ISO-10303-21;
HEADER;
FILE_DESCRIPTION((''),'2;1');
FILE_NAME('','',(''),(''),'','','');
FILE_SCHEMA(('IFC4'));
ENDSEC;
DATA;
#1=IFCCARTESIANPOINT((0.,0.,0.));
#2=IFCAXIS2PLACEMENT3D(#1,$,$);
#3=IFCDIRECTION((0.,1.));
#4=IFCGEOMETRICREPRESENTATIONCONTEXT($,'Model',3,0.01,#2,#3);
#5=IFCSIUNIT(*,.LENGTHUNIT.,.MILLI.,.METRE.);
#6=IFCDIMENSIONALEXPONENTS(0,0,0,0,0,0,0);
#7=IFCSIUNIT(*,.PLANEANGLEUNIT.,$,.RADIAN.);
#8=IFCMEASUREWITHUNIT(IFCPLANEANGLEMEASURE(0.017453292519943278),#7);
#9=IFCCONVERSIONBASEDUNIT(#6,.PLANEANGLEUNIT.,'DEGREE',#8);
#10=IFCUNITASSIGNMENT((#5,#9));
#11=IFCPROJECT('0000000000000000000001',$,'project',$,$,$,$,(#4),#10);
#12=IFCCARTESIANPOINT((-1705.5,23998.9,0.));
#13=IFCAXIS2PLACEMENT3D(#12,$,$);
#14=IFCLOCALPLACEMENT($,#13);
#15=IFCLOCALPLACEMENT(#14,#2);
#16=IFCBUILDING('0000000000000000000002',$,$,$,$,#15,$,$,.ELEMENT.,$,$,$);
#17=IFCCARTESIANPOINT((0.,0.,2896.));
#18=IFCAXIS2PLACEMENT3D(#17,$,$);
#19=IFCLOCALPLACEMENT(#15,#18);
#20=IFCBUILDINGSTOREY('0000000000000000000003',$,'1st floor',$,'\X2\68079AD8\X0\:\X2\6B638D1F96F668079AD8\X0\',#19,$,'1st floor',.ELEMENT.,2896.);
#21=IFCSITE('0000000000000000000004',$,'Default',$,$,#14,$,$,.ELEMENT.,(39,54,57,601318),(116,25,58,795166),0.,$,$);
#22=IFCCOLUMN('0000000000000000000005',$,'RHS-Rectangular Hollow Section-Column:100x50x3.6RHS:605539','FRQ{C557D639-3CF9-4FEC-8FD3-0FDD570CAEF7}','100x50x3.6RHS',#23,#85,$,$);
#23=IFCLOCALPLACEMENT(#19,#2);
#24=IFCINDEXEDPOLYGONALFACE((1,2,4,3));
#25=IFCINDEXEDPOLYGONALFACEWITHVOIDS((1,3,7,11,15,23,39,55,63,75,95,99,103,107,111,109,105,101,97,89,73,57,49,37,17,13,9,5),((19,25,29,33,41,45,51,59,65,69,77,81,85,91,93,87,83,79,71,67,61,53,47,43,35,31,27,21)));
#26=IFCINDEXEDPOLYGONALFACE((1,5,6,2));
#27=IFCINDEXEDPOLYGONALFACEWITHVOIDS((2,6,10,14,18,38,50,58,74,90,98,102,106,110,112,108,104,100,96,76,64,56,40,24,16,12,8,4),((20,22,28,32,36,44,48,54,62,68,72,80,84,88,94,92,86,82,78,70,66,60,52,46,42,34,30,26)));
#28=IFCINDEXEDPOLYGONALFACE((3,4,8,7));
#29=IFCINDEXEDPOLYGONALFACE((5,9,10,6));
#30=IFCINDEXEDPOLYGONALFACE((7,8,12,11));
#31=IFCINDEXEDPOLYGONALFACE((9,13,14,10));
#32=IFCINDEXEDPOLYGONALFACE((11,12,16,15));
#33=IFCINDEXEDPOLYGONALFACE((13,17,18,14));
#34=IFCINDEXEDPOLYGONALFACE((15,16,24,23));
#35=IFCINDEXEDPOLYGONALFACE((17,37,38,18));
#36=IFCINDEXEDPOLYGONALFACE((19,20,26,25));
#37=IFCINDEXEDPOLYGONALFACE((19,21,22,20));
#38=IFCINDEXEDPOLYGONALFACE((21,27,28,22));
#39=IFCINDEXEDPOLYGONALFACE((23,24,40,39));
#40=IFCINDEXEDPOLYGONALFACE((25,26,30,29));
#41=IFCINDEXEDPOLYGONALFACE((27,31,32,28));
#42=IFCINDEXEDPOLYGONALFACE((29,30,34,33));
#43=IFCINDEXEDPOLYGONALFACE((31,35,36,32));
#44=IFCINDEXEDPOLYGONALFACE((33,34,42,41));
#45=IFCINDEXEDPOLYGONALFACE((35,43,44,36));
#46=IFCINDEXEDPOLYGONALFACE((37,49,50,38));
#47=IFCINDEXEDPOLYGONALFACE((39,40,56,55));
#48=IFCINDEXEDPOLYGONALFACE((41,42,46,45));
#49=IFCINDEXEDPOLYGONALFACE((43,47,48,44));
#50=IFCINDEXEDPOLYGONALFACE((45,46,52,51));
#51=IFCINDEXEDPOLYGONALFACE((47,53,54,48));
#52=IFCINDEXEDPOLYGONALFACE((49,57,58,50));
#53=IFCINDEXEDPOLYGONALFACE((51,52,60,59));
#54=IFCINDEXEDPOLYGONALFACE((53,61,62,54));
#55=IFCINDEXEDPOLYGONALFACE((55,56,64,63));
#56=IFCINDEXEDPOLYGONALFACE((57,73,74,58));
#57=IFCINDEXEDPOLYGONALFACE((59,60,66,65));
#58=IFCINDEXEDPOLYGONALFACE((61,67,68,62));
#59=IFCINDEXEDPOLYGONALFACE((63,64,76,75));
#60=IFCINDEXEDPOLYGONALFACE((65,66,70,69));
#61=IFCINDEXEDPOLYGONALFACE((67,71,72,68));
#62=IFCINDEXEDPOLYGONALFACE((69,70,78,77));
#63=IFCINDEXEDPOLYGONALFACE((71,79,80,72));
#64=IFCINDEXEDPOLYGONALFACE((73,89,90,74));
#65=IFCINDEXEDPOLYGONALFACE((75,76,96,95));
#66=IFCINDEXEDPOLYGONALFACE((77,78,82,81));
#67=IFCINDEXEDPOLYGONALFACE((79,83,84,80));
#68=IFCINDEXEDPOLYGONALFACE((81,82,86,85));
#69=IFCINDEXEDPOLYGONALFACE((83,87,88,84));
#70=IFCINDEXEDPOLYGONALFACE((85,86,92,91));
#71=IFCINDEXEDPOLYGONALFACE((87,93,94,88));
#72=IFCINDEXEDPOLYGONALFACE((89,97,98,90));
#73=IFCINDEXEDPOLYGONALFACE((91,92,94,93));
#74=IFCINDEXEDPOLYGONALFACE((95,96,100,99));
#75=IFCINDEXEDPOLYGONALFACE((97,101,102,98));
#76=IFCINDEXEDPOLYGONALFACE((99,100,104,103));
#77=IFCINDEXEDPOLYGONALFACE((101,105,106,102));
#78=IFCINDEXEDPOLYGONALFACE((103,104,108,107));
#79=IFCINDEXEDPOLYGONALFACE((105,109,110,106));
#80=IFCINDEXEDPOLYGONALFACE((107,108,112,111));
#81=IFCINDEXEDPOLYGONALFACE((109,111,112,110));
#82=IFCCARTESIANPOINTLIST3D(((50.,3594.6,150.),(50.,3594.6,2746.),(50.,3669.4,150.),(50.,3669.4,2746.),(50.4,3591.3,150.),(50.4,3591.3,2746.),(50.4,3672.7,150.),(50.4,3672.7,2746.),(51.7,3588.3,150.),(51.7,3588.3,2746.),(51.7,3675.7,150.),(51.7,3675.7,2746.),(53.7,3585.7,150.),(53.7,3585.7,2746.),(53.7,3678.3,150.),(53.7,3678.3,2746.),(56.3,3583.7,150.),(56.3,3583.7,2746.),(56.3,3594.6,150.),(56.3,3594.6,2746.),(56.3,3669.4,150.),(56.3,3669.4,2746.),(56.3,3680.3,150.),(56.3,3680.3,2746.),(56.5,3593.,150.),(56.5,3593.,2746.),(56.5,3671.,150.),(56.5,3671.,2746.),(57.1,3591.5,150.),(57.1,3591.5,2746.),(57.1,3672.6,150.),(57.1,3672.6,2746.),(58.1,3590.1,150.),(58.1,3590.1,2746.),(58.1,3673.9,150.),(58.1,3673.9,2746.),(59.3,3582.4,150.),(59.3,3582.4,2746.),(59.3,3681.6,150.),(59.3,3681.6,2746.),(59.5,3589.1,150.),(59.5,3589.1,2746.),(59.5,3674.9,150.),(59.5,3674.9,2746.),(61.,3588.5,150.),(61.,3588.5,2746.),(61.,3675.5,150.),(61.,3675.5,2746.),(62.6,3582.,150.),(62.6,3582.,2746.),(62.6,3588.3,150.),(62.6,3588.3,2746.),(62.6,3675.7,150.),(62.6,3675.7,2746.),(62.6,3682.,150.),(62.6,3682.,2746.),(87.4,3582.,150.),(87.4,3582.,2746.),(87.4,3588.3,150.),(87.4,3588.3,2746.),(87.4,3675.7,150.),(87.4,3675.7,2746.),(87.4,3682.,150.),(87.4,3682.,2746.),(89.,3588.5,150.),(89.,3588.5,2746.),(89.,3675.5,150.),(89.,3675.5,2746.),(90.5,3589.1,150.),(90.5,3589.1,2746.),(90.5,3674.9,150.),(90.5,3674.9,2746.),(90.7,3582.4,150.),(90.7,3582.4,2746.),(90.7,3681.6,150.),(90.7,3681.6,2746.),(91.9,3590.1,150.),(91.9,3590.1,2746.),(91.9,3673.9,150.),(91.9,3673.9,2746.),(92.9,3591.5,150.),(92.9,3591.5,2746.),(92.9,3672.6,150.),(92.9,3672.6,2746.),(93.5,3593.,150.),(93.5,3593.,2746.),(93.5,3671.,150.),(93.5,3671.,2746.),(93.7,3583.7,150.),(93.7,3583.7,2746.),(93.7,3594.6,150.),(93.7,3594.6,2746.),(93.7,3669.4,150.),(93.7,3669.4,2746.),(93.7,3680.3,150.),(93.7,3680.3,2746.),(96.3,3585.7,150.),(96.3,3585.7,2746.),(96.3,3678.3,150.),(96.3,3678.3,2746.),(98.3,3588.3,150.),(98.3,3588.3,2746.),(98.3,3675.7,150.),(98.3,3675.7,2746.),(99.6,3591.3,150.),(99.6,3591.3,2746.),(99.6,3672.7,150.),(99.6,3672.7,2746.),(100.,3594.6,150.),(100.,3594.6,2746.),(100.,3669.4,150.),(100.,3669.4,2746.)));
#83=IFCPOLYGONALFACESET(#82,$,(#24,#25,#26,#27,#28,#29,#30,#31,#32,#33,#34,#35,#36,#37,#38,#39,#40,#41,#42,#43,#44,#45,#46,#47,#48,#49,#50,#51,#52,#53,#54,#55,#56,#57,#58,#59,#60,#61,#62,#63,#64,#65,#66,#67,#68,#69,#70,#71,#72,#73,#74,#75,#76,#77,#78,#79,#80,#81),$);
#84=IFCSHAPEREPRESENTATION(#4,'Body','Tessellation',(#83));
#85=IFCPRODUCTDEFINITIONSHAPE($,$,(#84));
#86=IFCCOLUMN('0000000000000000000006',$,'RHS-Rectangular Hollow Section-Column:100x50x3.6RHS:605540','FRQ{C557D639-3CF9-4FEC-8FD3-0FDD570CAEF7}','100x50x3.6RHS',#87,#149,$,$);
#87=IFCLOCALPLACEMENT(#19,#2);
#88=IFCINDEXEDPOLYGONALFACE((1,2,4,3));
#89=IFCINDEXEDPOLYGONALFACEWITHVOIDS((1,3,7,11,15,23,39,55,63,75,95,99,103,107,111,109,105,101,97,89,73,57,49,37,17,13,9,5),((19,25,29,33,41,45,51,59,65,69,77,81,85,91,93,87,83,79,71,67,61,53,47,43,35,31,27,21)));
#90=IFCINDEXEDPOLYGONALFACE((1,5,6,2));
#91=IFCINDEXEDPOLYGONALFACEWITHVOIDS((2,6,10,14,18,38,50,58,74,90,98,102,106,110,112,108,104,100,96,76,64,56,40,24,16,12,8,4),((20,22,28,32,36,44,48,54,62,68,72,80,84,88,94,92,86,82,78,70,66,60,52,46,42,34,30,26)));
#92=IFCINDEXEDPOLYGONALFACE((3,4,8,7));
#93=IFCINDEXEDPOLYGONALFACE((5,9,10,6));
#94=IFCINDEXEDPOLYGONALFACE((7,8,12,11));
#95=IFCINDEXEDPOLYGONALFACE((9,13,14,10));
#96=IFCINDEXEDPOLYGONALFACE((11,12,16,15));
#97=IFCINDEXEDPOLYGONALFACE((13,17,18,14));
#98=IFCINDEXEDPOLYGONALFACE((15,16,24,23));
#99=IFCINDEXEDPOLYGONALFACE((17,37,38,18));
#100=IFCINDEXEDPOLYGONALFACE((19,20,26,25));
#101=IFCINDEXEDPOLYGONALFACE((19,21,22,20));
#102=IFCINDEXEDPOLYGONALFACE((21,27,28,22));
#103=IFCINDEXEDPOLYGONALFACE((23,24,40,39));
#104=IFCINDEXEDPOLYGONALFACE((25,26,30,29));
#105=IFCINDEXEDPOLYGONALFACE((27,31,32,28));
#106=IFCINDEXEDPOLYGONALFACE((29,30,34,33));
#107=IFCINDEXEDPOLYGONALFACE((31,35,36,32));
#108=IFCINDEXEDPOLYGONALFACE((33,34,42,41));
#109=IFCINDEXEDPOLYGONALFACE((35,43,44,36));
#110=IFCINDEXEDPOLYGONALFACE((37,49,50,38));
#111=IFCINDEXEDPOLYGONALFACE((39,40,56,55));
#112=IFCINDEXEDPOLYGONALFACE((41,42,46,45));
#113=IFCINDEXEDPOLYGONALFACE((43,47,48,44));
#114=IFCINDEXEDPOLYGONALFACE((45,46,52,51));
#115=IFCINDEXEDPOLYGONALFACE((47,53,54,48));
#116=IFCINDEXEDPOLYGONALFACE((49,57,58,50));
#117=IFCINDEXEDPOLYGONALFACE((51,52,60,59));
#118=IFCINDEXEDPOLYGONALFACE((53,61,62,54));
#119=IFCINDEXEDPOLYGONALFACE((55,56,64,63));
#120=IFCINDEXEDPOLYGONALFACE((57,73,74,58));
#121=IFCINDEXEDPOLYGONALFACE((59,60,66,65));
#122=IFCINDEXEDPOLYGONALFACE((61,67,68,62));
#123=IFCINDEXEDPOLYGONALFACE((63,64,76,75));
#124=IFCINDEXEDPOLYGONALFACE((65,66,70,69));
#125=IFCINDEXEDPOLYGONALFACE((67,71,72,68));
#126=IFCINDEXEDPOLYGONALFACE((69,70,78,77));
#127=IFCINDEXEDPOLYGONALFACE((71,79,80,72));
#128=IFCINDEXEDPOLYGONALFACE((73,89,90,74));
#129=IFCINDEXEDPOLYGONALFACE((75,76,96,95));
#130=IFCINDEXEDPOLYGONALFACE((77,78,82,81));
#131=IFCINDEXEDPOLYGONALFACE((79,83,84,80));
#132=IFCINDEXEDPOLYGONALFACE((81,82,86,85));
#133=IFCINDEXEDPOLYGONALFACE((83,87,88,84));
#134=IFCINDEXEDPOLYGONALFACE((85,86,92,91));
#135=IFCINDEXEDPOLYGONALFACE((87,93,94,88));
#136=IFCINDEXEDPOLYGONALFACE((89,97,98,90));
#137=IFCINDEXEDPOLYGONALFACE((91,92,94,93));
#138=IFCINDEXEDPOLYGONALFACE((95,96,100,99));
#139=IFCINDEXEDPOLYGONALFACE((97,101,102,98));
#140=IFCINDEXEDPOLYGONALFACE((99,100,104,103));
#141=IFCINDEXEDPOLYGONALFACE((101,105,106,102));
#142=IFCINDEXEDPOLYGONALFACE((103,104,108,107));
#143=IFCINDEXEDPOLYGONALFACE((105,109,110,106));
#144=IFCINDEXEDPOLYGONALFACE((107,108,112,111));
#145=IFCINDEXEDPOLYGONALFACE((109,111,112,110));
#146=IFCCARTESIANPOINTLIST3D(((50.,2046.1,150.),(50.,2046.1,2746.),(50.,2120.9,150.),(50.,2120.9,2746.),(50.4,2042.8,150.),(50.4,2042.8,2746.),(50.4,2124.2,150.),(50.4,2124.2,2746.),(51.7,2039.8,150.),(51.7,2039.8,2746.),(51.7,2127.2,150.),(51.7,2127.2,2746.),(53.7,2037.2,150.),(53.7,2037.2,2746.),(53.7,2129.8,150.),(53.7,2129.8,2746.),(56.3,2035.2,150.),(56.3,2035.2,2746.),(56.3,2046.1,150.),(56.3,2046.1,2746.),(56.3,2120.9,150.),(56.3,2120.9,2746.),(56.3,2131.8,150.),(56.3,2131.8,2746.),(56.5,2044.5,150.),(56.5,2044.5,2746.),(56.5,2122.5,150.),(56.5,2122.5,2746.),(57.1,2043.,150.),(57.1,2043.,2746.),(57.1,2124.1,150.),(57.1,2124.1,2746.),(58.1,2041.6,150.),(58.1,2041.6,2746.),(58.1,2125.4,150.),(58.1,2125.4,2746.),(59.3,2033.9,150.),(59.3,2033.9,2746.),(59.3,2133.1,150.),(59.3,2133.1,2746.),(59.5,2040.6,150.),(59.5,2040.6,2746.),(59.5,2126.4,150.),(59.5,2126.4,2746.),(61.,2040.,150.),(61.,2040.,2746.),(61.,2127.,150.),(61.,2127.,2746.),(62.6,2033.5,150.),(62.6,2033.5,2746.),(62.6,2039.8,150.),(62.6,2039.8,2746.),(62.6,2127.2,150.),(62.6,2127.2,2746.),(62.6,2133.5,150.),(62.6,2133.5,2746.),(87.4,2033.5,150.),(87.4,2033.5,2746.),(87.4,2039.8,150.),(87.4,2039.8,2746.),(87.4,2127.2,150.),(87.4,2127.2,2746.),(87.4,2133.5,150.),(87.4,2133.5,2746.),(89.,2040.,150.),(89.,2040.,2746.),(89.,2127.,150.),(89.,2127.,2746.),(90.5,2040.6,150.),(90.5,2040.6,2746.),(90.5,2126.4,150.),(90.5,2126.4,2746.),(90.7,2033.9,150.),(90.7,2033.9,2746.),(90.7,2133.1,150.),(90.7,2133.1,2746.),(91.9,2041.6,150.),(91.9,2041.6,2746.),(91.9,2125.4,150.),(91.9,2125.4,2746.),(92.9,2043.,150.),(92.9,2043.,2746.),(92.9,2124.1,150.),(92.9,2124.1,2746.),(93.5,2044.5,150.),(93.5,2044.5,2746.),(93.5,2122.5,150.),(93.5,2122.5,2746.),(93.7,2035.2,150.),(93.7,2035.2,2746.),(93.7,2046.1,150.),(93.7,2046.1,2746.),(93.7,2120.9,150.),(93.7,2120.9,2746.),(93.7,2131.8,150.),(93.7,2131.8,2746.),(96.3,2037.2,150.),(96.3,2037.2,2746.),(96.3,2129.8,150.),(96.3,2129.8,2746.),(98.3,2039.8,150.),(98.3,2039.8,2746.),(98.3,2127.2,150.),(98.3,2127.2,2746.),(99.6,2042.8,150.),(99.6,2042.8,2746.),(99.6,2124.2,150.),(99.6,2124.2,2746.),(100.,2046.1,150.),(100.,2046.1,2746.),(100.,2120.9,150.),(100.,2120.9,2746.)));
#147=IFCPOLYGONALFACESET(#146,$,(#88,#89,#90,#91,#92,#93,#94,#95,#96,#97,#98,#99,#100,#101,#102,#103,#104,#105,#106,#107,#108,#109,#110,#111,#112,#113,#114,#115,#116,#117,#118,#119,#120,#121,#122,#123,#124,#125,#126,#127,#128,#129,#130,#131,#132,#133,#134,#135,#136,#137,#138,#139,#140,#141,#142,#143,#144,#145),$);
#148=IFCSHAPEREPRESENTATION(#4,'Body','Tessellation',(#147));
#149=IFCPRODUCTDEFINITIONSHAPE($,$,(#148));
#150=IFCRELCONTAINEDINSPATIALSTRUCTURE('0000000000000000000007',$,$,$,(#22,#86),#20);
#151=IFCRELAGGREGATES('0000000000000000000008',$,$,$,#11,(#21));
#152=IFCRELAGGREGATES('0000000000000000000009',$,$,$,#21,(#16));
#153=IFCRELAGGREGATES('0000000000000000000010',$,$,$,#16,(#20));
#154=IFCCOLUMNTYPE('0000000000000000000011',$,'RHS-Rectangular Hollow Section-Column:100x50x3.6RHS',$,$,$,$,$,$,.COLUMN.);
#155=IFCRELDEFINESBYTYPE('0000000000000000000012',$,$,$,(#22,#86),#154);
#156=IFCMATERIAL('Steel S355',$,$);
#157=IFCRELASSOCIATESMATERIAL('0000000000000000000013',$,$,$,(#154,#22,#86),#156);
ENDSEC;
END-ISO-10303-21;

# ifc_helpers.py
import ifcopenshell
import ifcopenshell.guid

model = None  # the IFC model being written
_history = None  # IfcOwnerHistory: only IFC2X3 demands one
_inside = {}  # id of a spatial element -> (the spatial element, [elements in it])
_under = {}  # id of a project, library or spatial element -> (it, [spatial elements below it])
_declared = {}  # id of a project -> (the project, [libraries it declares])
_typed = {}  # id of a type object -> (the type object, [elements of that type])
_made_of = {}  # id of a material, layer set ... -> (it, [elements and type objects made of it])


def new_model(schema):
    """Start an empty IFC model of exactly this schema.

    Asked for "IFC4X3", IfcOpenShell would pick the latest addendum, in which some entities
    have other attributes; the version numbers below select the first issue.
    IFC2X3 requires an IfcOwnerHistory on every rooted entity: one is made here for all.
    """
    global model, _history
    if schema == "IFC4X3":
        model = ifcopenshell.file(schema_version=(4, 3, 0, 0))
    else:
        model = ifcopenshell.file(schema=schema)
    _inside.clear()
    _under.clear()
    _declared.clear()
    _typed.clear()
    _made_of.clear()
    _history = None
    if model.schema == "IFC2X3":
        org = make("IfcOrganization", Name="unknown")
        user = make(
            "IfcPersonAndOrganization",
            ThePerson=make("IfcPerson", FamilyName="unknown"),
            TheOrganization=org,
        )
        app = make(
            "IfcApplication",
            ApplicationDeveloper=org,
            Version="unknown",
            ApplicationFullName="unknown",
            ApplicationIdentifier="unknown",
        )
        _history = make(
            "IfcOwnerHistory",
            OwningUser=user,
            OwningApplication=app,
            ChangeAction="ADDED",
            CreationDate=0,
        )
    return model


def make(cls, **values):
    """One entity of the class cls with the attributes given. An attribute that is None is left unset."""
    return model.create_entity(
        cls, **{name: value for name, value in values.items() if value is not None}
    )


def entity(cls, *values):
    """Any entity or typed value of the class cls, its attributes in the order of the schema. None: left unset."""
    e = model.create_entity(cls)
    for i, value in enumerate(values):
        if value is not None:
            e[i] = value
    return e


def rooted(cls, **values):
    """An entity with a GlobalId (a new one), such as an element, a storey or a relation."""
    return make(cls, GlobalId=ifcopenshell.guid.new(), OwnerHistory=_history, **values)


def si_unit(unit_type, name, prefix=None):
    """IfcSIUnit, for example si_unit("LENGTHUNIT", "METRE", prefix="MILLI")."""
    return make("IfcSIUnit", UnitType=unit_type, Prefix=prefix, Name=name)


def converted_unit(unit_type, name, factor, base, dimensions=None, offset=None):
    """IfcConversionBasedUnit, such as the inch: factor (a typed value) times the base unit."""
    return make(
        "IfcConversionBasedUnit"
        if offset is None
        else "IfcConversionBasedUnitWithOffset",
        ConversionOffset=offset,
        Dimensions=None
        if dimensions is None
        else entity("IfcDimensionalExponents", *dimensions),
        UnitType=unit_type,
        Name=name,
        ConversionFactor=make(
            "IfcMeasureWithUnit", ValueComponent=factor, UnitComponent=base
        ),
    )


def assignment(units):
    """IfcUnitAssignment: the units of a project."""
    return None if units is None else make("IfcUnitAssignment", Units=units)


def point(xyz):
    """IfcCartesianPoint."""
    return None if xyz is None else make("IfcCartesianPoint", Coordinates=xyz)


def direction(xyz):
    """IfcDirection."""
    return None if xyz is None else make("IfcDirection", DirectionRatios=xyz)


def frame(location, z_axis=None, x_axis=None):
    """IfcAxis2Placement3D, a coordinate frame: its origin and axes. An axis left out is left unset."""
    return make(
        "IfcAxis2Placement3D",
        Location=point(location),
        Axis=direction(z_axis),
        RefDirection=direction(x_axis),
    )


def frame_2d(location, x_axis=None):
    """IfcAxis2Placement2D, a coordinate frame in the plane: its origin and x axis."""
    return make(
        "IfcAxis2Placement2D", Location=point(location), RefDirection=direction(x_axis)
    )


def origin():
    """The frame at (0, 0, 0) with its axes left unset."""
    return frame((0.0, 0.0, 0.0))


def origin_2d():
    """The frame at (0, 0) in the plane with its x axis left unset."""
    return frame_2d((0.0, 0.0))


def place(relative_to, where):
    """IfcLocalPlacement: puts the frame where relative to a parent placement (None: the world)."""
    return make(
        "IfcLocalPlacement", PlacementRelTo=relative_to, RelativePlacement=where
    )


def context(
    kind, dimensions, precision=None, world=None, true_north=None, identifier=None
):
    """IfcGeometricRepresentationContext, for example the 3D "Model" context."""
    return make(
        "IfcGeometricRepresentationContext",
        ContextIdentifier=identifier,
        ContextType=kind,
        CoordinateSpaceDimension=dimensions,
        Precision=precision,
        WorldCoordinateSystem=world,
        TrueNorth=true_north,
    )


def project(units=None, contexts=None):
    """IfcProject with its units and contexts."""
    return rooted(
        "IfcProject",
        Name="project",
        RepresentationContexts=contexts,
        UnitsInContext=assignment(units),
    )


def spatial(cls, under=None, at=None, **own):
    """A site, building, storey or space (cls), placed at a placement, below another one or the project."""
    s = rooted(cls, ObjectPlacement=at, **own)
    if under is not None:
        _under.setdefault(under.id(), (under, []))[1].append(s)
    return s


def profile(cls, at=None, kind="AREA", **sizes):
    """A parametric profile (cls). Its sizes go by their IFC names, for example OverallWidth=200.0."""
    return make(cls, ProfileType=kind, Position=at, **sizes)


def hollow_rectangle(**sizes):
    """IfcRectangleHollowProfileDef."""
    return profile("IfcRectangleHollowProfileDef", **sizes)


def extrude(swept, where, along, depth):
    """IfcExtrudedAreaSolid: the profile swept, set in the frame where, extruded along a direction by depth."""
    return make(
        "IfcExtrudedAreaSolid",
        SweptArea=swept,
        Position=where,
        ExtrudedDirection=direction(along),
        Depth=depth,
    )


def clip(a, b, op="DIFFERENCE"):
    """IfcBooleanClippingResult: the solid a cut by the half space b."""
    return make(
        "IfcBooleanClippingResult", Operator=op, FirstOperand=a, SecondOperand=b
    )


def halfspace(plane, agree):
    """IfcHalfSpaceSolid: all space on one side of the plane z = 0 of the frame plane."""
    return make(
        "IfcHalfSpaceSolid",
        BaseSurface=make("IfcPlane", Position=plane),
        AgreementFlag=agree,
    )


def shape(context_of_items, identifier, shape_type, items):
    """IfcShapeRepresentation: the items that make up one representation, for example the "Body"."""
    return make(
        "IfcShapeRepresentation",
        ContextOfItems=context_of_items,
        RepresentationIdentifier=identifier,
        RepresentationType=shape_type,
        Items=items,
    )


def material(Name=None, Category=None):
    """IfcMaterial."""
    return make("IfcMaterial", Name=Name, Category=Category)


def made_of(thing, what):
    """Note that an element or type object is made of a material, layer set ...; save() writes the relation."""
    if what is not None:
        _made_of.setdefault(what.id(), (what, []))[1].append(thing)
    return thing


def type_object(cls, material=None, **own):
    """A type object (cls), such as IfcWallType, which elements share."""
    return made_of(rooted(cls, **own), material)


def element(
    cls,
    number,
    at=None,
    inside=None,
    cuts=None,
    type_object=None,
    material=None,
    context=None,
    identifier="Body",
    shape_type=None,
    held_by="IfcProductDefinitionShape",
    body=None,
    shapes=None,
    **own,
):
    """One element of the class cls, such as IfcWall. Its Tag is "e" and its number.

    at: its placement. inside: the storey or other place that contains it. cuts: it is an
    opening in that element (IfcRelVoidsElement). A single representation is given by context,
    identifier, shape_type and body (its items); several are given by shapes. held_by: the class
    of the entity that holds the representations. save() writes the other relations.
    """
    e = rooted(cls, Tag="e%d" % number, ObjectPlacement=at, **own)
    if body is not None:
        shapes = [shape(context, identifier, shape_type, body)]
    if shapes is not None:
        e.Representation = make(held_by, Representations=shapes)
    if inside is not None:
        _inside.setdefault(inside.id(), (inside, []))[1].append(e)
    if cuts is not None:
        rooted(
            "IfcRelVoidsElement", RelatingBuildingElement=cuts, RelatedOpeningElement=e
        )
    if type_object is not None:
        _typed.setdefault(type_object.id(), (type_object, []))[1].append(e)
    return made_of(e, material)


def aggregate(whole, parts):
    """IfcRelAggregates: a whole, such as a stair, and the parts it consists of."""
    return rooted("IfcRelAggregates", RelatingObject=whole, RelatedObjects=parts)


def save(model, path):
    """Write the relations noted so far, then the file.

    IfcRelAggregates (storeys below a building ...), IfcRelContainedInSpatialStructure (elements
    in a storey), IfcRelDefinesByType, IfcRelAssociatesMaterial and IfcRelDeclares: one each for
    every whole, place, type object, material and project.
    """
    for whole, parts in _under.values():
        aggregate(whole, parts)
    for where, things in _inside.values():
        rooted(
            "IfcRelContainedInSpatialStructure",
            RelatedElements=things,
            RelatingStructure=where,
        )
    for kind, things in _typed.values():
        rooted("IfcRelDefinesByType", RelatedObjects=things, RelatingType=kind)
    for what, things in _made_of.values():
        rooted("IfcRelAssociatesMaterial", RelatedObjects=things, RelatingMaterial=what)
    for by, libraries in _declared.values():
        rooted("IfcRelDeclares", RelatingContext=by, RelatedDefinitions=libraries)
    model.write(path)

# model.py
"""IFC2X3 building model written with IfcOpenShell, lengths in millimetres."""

from ifc_helpers import new_model, entity, si_unit, converted_unit, direction, frame, origin, origin_2d, place, context, project, spatial, hollow_rectangle, extrude, clip, halfspace, material, type_object, element, save


model = new_model("IFC2X3")

# Units and contexts
model_context = context("Model", 3, precision=0.01, world=origin(), true_north=direction((0.0, 1.0)))
ifc_project = project(units=[si_unit("LENGTHUNIT", "METRE", prefix="MILLI"), converted_unit("PLANEANGLEUNIT", "DEGREE", entity("IfcPlaneAngleMeasure", 0.017453292519943278), si_unit("PLANEANGLEUNIT", "RADIAN"), dimensions=[0, 0, 0, 0, 0, 0, 0])], contexts=[model_context])

# Site, building, storey
site_placement = place(None, frame((-1705.5, 23998.9, 0.0)))
site = spatial("IfcSite", under=ifc_project, at=site_placement, Name="Default", CompositionType="ELEMENT", RefLatitude=(39, 54, 57, 601318), RefLongitude=(116, 25, 58, 795166), RefElevation=0.0)
building_placement = place(site_placement, origin())
building = spatial("IfcBuilding", under=site, at=building_placement, CompositionType="ELEMENT")
storey_placement = place(building_placement, frame((0.0, 0.0, 2896.0)))
storey = spatial("IfcBuildingStorey", under=building, at=storey_placement, Name="1st floor", ObjectType="标高:正负零标高", LongName="1st floor", CompositionType="ELEMENT", Elevation=2896.0)

# Shared definitions
ifc_material_1 = material(Name="Steel S355")

# Columns
column_type_1 = type_object("IfcColumnType", Name="RHS-Rectangular Hollow Section-Column:100x50x3.6RHS", PredefinedType="COLUMN", material=ifc_material_1)
column_1_placement = place(storey_placement, frame((75.0, 3632.0, 2746.0), z_axis=(0.0, 0.0, 1.0), x_axis=(-1.0, 0.0, 0.0)))
element("IfcColumn", 1, at=column_1_placement, inside=storey, type_object=column_type_1, material=ifc_material_1, Name="RHS-Rectangular Hollow Section-Column:100x50x3.6RHS:605539", Description="FRQ{C557D639-3CF9-4FEC-8FD3-0FDD570CAEF7}", ObjectType="100x50x3.6RHS", context=model_context, shape_type="Clipping", body=[
    clip(extrude(hollow_rectangle(XDim=50.0, YDim=100.0, WallThickness=6.3, InnerFilletRadius=6.3, OuterFilletRadius=12.6, at=origin_2d()), origin(), (0.0, 0.0, -1.0), 2651.9), halfspace(frame((75.0, 3632.0, -2596.0), z_axis=(0.0, 0.0, 1.0), x_axis=(-1.0, 0.0, 0.0)), True)),
])
column_2_placement = place(storey_placement, frame((75.0, 2083.5, 2746.0), z_axis=(0.0, 0.0, 1.0), x_axis=(-1.0, 0.0, 0.0)))
element("IfcColumn", 2, at=column_2_placement, inside=storey, type_object=column_type_1, material=ifc_material_1, Name="RHS-Rectangular Hollow Section-Column:100x50x3.6RHS:605540", Description="FRQ{C557D639-3CF9-4FEC-8FD3-0FDD570CAEF7}", ObjectType="100x50x3.6RHS", context=model_context, shape_type="Clipping", body=[
    clip(extrude(hollow_rectangle(XDim=50.0, YDim=100.0, WallThickness=6.3, InnerFilletRadius=6.3, OuterFilletRadius=12.6, at=origin_2d()), origin(), (0.0, 0.0, -1.0), 2651.9), halfspace(frame((75.0, 2083.5, -2596.0), z_axis=(0.0, 0.0, 1.0), x_axis=(-1.0, 0.0, 0.0)), True)),
])

save(model, "model.ifc")
